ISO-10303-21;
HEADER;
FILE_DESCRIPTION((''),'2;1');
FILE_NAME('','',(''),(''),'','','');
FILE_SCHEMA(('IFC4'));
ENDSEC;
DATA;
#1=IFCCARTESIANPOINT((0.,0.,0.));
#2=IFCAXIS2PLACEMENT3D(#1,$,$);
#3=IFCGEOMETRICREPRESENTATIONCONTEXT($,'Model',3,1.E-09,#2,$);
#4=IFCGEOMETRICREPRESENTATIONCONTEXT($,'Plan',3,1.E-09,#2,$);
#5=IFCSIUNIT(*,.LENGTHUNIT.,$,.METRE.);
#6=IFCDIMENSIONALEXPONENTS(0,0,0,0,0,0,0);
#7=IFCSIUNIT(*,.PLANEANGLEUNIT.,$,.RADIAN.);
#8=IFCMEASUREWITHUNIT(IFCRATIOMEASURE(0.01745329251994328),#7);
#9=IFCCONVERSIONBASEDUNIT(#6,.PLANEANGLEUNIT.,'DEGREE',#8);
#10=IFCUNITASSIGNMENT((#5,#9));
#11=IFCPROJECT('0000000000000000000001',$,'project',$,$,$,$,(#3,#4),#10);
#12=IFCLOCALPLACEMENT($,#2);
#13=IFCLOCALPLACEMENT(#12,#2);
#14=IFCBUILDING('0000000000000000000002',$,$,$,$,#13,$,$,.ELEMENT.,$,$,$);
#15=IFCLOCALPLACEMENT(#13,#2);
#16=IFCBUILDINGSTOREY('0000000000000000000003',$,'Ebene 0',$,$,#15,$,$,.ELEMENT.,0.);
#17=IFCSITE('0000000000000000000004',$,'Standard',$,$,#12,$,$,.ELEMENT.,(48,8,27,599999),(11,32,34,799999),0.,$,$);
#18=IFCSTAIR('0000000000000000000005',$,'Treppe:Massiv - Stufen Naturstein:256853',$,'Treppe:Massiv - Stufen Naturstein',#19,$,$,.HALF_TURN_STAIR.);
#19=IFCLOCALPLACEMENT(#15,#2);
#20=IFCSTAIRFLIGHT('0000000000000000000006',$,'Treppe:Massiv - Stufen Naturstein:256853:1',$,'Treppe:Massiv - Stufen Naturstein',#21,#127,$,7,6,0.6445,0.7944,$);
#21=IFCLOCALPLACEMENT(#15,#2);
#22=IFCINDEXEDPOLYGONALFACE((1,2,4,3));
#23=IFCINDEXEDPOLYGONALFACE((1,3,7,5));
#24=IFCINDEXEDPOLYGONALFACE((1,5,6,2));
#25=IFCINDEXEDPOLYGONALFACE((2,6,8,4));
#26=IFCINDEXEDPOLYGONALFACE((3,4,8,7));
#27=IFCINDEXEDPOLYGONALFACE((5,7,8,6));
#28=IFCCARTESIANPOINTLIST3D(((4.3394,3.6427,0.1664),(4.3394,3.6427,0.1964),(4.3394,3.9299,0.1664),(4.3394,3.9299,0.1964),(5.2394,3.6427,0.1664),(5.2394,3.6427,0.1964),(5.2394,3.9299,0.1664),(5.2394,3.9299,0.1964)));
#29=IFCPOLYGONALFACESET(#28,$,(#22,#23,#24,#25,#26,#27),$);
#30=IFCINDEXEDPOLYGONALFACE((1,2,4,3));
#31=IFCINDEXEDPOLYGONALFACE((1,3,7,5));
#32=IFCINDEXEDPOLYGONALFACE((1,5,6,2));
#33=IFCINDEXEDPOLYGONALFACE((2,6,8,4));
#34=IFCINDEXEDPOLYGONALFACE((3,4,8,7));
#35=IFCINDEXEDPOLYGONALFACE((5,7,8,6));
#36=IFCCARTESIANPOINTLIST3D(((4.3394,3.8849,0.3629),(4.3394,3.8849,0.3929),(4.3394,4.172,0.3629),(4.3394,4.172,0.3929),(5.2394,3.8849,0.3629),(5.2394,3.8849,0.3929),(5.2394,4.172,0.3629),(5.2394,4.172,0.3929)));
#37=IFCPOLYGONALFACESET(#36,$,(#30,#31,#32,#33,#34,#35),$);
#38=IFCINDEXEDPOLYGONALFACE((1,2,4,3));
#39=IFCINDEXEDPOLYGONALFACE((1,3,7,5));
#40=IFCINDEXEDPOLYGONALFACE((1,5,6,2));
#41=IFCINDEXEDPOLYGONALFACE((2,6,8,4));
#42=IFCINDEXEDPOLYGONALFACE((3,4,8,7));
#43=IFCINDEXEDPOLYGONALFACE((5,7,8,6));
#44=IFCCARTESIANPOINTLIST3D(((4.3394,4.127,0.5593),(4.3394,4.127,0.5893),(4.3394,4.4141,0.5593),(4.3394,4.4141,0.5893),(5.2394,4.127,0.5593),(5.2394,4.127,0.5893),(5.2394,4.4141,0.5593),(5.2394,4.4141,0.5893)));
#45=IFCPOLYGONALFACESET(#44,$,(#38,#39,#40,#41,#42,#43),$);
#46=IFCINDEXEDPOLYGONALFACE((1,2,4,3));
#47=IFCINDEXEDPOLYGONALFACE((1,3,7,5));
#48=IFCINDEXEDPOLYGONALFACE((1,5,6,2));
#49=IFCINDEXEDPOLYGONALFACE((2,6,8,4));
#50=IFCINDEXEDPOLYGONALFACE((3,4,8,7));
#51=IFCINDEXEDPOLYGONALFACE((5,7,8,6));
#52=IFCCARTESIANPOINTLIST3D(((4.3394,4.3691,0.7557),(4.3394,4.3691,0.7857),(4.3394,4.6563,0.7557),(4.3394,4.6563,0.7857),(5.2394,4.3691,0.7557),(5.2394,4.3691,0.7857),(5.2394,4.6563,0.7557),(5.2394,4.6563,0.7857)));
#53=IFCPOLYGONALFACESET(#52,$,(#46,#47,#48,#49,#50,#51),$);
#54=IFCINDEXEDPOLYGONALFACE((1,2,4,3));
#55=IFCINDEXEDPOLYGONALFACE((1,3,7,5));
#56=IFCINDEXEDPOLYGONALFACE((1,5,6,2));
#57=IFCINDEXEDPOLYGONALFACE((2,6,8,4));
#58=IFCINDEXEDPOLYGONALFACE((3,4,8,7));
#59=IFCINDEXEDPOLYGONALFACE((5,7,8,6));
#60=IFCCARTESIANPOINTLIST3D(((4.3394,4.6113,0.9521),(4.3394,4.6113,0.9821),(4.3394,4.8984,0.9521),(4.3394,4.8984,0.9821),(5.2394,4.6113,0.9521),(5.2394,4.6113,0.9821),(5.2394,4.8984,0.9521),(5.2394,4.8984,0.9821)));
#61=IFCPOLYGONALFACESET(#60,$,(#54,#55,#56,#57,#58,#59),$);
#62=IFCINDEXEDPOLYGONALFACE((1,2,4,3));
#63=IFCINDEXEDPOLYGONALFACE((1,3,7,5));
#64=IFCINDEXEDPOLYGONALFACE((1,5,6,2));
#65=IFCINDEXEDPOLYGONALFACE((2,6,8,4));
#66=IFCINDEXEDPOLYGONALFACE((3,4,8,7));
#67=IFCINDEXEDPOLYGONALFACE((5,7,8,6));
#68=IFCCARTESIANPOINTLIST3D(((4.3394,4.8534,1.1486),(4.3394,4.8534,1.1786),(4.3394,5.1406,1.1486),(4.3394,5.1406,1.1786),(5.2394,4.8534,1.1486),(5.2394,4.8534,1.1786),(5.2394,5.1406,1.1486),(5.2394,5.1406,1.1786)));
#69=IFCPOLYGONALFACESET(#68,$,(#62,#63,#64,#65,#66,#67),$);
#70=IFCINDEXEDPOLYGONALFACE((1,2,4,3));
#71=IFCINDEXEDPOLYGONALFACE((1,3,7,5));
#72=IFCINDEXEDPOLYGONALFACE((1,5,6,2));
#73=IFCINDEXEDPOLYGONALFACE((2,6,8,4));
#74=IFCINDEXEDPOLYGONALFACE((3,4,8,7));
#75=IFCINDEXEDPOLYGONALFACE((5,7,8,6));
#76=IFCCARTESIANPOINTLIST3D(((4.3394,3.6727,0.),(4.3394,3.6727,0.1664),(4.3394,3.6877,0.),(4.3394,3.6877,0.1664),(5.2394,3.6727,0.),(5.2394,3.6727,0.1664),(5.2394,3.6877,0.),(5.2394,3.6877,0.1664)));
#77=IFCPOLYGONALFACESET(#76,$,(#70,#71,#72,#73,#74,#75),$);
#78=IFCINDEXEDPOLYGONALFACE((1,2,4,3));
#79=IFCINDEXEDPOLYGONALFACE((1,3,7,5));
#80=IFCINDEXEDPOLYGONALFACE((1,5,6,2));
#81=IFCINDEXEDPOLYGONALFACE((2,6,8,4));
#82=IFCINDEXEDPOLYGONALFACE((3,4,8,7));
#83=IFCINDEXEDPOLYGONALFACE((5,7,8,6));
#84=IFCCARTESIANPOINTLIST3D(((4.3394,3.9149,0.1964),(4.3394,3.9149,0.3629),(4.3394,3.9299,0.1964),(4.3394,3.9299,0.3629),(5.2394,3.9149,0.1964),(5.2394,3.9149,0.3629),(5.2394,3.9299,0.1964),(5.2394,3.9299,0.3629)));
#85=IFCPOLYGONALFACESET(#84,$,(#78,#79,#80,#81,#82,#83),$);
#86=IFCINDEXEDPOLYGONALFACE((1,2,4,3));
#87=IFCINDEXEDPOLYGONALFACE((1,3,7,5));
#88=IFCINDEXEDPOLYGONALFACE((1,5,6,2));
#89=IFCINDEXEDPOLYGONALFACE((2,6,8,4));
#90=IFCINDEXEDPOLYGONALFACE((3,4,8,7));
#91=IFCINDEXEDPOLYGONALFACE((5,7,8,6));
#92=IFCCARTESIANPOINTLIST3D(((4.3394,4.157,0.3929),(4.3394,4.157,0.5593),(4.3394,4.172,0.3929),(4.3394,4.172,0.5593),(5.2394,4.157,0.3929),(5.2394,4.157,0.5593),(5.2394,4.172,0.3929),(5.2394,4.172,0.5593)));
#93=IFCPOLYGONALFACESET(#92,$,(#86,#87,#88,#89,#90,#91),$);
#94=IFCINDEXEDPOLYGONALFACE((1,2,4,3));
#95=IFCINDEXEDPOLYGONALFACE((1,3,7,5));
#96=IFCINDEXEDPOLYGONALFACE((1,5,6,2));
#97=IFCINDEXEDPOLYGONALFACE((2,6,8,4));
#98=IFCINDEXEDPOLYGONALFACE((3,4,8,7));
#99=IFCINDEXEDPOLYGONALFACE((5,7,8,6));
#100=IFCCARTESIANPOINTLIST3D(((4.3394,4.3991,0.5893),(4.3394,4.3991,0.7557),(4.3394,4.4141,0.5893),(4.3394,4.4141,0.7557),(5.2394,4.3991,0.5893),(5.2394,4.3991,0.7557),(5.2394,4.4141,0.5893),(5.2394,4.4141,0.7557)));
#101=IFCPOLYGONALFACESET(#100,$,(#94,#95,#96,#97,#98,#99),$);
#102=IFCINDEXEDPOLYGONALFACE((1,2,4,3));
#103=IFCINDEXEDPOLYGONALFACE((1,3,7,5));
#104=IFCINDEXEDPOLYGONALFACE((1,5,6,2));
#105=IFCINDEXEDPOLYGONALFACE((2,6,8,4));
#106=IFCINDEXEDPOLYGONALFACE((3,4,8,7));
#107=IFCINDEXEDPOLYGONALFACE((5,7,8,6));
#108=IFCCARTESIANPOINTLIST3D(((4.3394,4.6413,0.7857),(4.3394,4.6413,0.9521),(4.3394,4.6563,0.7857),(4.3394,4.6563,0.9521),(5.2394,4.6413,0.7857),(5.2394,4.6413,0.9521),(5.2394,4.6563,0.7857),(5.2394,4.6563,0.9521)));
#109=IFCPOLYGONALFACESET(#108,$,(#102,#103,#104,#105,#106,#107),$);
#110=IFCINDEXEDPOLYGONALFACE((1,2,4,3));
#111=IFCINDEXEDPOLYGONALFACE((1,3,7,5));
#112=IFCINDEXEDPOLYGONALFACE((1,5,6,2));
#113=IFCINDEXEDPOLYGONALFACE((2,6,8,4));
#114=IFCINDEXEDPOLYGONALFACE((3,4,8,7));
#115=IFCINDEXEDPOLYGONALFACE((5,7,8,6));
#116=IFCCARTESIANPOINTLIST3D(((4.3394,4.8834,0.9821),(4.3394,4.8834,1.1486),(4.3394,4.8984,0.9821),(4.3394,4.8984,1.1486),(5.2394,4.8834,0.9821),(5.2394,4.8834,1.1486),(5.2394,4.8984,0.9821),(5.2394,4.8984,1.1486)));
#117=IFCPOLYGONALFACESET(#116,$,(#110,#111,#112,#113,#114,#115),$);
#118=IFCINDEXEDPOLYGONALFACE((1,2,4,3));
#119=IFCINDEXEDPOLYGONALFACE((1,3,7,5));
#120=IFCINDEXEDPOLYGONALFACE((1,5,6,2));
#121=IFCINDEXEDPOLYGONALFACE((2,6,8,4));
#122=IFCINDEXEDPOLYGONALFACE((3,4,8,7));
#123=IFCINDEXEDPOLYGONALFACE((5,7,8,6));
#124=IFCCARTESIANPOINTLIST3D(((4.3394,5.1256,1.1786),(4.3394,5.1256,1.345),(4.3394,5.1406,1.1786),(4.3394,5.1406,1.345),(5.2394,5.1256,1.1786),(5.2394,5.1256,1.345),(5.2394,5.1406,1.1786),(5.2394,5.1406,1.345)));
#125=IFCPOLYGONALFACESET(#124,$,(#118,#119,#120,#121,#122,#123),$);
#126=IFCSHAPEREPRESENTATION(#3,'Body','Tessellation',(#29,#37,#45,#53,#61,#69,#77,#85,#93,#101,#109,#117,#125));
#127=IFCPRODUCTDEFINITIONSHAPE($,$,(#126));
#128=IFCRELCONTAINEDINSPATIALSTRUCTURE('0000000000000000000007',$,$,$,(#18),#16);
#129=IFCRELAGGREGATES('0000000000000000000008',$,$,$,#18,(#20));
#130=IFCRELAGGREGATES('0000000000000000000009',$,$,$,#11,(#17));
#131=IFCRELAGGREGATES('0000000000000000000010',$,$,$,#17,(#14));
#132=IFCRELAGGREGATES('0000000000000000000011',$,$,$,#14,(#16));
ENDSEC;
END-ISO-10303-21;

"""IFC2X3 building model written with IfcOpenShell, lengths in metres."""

from ifc_helpers import new_model, entity, si_unit, converted_unit, frame, frame_2d, origin, origin_2d_with_axis, place, context, project, spatial, rectangle, extrude, element, aggregate, save


model = new_model("IFC2X3")

# Units and contexts
plan_context = context("Plan", 3, precision=1e-09, world=origin())
model_context = context("Model", 3, precision=1e-09, world=origin())
ifc_project = project(units=[si_unit("LENGTHUNIT", "METRE"), converted_unit("PLANEANGLEUNIT", "DEGREE", entity("IfcRatioMeasure", 0.01745329251994328), si_unit("PLANEANGLEUNIT", "RADIAN"), dimensions=[0, 0, 0, 0, 0, 0, 0])], contexts=[model_context, plan_context])

# Site, building, storey
site_placement = place(None, origin())
site = spatial("IfcSite", under=ifc_project, at=site_placement, Name="Standard", CompositionType="ELEMENT", RefLatitude=(48, 8, 27, 599999), RefLongitude=(11, 32, 34, 799999), RefElevation=0.0)
building_placement = place(site_placement, origin())
building = spatial("IfcBuilding", under=site, at=building_placement, CompositionType="ELEMENT")
storey_placement = place(building_placement, origin())
storey = spatial("IfcBuildingStorey", under=building, at=storey_placement, Name="Ebene 0", CompositionType="ELEMENT", Elevation=0.0)

# Stair, stair flight
stair_placement = place(storey_placement, origin())
stair = element("IfcStair", 1, at=stair_placement, inside=storey, Name="Treppe:Massiv - Stufen Naturstein:256853", ObjectType="Treppe:Massiv - Stufen Naturstein", ShapeType="HALF_TURN_STAIR")
stair_flight_1_placement = place(storey_placement, origin())
stair_flight_1 = element("IfcStairFlight", 2, at=stair_flight_1_placement, Name="Treppe:Massiv - Stufen Naturstein:256853:1", ObjectType="Treppe:Massiv - Stufen Naturstein", NumberOfRiser=7, NumberOfTreads=6, RiserHeight=0.6445, TreadLength=0.7944, context=model_context, shape_type="SweptSolid", body=[
    extrude(rectangle(XDim=0.2871, YDim=0.9, at=origin_2d_with_axis()), frame((4.7894, 3.7863, 0.1664), z_axis=(0.0, 0.0, 1.0), x_axis=(0.0, -1.0, 0.0)), (0.0, 0.0, 1.0), 0.03),
    extrude(rectangle(XDim=0.2871, YDim=0.9, at=origin_2d_with_axis()), frame((4.7894, 4.0284, 0.3629), z_axis=(0.0, 0.0, 1.0), x_axis=(0.0, -1.0, 0.0)), (0.0, 0.0, 1.0), 0.03),
    extrude(rectangle(XDim=0.2871, YDim=0.9, at=origin_2d_with_axis()), frame((4.7894, 4.2706, 0.5593), z_axis=(0.0, 0.0, 1.0), x_axis=(0.0, -1.0, 0.0)), (0.0, 0.0, 1.0), 0.03),
    extrude(rectangle(XDim=0.2871, YDim=0.9, at=origin_2d_with_axis()), frame((4.7894, 4.5127, 0.7557), z_axis=(0.0, 0.0, 1.0), x_axis=(0.0, -1.0, 0.0)), (0.0, 0.0, 1.0), 0.03),
    extrude(rectangle(XDim=0.2871, YDim=0.9, at=origin_2d_with_axis()), frame((4.7894, 4.7549, 0.9521), z_axis=(0.0, 0.0, 1.0), x_axis=(0.0, -1.0, 0.0)), (0.0, 0.0, 1.0), 0.03),
    extrude(rectangle(XDim=0.2871, YDim=0.9, at=frame_2d((0.0329, 0.0), x_axis=(1.0, 0.0))), frame((4.7894, 5.0299, 1.1486), z_axis=(0.0, 0.0, 1.0), x_axis=(0.0, -1.0, 0.0)), (0.0, 0.0, 1.0), 0.03),
    extrude(rectangle(XDim=0.9, YDim=0.015, at=origin_2d_with_axis()), frame((4.7894, 3.6802, 0.0), z_axis=(0.0, 0.0, 1.0), x_axis=(-1.0, 0.0, 0.0)), (0.0, 0.0, 1.0), 0.1664),
    extrude(rectangle(XDim=0.9, YDim=0.015, at=origin_2d_with_axis()), frame((4.7894, 3.9224, 0.1964), z_axis=(0.0, 0.0, 1.0), x_axis=(-1.0, 0.0, 0.0)), (0.0, 0.0, 1.0), 0.1664),
    extrude(rectangle(XDim=0.9, YDim=0.015, at=origin_2d_with_axis()), frame((4.7894, 4.1645, 0.3929), z_axis=(0.0, 0.0, 1.0), x_axis=(-1.0, 0.0, 0.0)), (0.0, 0.0, 1.0), 0.1664),
    extrude(rectangle(XDim=0.9, YDim=0.015, at=origin_2d_with_axis()), frame((4.7894, 4.4066, 0.5893), z_axis=(0.0, 0.0, 1.0), x_axis=(-1.0, 0.0, 0.0)), (0.0, 0.0, 1.0), 0.1664),
    extrude(rectangle(XDim=0.9, YDim=0.015, at=origin_2d_with_axis()), frame((4.7894, 4.6488, 0.7857), z_axis=(0.0, 0.0, 1.0), x_axis=(-1.0, 0.0, 0.0)), (0.0, 0.0, 1.0), 0.1664),
    extrude(rectangle(XDim=0.9, YDim=0.015, at=origin_2d_with_axis()), frame((4.7894, 4.8909, 0.9821), z_axis=(0.0, 0.0, 1.0), x_axis=(-1.0, 0.0, 0.0)), (0.0, 0.0, 1.0), 0.1664),
    extrude(rectangle(XDim=0.9, YDim=0.015, at=origin_2d_with_axis()), frame((4.7894, 5.1331, 1.1786), z_axis=(0.0, 0.0, 1.0), x_axis=(-1.0, 0.0, 0.0)), (0.0, 0.0, 1.0), 0.1664),
])
aggregate(stair, [stair_flight_1])

save(model, "model.ifc")
